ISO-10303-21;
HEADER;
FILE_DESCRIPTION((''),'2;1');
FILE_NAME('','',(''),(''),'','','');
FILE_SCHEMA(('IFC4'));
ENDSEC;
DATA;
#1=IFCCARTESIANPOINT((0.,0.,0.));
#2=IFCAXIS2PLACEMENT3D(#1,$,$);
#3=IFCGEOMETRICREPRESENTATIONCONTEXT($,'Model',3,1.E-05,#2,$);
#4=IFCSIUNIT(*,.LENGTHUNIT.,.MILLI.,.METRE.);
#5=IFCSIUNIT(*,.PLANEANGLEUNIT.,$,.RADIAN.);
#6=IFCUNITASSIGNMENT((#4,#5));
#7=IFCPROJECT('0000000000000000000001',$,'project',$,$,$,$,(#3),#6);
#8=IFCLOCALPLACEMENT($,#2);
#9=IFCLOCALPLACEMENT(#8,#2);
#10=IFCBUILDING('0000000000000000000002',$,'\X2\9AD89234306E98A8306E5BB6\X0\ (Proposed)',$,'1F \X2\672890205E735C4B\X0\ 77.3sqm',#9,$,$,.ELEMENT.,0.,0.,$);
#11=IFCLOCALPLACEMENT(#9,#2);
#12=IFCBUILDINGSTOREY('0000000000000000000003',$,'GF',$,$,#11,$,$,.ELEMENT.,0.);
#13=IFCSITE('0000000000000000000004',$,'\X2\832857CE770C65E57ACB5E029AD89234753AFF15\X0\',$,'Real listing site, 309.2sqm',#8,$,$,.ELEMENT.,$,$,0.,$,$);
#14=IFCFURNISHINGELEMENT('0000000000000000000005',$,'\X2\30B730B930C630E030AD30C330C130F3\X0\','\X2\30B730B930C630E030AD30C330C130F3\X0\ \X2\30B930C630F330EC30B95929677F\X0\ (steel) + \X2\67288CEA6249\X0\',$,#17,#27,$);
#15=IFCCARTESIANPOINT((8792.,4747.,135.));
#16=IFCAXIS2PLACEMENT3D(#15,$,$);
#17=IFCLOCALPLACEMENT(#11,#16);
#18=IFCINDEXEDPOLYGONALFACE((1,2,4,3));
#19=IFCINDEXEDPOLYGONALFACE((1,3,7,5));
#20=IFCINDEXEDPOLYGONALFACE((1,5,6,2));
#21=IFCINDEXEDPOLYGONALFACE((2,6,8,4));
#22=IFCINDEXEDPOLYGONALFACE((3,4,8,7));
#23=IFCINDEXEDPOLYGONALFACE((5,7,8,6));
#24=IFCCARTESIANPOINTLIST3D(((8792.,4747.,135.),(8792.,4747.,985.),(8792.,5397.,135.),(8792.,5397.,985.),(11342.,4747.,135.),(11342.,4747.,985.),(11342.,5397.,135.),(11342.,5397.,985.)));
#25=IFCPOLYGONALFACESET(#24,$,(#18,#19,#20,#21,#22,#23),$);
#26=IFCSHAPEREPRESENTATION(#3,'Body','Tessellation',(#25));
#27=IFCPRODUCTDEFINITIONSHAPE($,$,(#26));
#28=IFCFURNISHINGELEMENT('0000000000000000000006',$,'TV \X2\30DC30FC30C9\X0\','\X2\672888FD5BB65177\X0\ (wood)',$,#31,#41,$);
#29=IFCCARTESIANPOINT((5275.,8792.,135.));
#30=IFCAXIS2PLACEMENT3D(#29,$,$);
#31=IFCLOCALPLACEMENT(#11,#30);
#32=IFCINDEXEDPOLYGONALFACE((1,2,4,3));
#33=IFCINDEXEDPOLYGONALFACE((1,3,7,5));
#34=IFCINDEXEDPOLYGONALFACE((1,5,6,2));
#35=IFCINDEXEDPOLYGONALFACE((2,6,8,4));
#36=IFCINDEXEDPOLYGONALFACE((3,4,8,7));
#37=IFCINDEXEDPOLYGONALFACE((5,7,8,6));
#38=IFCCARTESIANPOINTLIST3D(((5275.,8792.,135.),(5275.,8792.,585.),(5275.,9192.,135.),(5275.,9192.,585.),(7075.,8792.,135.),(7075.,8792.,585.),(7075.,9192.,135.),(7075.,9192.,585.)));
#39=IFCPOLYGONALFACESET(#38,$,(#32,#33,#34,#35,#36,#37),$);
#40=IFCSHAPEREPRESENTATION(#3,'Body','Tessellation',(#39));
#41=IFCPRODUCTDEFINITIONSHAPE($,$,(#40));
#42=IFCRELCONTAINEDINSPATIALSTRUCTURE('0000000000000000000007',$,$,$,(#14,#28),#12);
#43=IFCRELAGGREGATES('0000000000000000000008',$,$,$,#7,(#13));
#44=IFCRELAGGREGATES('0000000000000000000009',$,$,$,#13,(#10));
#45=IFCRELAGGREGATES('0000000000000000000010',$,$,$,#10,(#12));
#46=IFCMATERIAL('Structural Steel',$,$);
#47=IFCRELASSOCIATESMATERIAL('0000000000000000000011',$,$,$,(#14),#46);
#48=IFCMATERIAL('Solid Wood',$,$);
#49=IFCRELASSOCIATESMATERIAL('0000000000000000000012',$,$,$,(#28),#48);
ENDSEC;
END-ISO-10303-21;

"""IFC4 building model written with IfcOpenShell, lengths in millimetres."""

from ifc_helpers import new_model, si_unit, frame, frame_2d, origin, place, context, project, spatial, rectangle, extrude, material, element, save


model = new_model("IFC4")

# Units and contexts
model_context = context("Model", 3, precision=1e-05, world=origin())
ifc_project = project(units=[si_unit("LENGTHUNIT", "METRE", prefix="MILLI"), si_unit("PLANEANGLEUNIT", "RADIAN")], contexts=[model_context])

# Site, building, storey
site_placement = place(None, origin())
site = spatial("IfcSite", under=ifc_project, at=site_placement, Name="茨城県日立市高鈴町５", ObjectType="Real listing site, 309.2sqm", CompositionType="ELEMENT", RefElevation=0.0)
building_placement = place(site_placement, origin())
building = spatial("IfcBuilding", under=site, at=building_placement, Name="高鈴の風の家 (Proposed)", ObjectType="1F 木造平屋 77.3sqm", CompositionType="ELEMENT", ElevationOfRefHeight=0.0, ElevationOfTerrain=0.0)
storey_placement = place(building_placement, origin())
storey = spatial("IfcBuildingStorey", under=building, at=storey_placement, Name="GF", CompositionType="ELEMENT", Elevation=0.0)

# Shared definitions
ifc_material_1 = material(Name="Solid Wood")

# Furnishing elements
ifc_material_2 = material(Name="Structural Steel")
furnishing_1_placement = place(storey_placement, frame((8792.0, 4747.0, 135.0)))
element("IfcFurnishingElement", 1, at=furnishing_1_placement, inside=storey, material=ifc_material_2, Name="システムキッチン", Description="システムキッチン ステンレス天板 (steel) + 木質扉", context=model_context, shape_type="SweptSolid", body=[
    extrude(rectangle(XDim=2550.0, YDim=650.0, at=frame_2d((1275.0, 325.0))), frame((8792.0, 4747.0, 135.0)), (0.0, 0.0, 1.0), 850.0),
])
furnishing_2_placement = place(storey_placement, frame((5275.0, 8792.0, 135.0)))
element("IfcFurnishingElement", 2, at=furnishing_2_placement, inside=storey, material=ifc_material_1, Name="TV ボード", Description="木製家具 (wood)", context=model_context, shape_type="SweptSolid", body=[
    extrude(rectangle(XDim=1800.0, YDim=400.0, at=frame_2d((900.0, 200.0))), frame((5275.0, 8792.0, 135.0)), (0.0, 0.0, 1.0), 450.0),
])

save(model, "model.ifc")
